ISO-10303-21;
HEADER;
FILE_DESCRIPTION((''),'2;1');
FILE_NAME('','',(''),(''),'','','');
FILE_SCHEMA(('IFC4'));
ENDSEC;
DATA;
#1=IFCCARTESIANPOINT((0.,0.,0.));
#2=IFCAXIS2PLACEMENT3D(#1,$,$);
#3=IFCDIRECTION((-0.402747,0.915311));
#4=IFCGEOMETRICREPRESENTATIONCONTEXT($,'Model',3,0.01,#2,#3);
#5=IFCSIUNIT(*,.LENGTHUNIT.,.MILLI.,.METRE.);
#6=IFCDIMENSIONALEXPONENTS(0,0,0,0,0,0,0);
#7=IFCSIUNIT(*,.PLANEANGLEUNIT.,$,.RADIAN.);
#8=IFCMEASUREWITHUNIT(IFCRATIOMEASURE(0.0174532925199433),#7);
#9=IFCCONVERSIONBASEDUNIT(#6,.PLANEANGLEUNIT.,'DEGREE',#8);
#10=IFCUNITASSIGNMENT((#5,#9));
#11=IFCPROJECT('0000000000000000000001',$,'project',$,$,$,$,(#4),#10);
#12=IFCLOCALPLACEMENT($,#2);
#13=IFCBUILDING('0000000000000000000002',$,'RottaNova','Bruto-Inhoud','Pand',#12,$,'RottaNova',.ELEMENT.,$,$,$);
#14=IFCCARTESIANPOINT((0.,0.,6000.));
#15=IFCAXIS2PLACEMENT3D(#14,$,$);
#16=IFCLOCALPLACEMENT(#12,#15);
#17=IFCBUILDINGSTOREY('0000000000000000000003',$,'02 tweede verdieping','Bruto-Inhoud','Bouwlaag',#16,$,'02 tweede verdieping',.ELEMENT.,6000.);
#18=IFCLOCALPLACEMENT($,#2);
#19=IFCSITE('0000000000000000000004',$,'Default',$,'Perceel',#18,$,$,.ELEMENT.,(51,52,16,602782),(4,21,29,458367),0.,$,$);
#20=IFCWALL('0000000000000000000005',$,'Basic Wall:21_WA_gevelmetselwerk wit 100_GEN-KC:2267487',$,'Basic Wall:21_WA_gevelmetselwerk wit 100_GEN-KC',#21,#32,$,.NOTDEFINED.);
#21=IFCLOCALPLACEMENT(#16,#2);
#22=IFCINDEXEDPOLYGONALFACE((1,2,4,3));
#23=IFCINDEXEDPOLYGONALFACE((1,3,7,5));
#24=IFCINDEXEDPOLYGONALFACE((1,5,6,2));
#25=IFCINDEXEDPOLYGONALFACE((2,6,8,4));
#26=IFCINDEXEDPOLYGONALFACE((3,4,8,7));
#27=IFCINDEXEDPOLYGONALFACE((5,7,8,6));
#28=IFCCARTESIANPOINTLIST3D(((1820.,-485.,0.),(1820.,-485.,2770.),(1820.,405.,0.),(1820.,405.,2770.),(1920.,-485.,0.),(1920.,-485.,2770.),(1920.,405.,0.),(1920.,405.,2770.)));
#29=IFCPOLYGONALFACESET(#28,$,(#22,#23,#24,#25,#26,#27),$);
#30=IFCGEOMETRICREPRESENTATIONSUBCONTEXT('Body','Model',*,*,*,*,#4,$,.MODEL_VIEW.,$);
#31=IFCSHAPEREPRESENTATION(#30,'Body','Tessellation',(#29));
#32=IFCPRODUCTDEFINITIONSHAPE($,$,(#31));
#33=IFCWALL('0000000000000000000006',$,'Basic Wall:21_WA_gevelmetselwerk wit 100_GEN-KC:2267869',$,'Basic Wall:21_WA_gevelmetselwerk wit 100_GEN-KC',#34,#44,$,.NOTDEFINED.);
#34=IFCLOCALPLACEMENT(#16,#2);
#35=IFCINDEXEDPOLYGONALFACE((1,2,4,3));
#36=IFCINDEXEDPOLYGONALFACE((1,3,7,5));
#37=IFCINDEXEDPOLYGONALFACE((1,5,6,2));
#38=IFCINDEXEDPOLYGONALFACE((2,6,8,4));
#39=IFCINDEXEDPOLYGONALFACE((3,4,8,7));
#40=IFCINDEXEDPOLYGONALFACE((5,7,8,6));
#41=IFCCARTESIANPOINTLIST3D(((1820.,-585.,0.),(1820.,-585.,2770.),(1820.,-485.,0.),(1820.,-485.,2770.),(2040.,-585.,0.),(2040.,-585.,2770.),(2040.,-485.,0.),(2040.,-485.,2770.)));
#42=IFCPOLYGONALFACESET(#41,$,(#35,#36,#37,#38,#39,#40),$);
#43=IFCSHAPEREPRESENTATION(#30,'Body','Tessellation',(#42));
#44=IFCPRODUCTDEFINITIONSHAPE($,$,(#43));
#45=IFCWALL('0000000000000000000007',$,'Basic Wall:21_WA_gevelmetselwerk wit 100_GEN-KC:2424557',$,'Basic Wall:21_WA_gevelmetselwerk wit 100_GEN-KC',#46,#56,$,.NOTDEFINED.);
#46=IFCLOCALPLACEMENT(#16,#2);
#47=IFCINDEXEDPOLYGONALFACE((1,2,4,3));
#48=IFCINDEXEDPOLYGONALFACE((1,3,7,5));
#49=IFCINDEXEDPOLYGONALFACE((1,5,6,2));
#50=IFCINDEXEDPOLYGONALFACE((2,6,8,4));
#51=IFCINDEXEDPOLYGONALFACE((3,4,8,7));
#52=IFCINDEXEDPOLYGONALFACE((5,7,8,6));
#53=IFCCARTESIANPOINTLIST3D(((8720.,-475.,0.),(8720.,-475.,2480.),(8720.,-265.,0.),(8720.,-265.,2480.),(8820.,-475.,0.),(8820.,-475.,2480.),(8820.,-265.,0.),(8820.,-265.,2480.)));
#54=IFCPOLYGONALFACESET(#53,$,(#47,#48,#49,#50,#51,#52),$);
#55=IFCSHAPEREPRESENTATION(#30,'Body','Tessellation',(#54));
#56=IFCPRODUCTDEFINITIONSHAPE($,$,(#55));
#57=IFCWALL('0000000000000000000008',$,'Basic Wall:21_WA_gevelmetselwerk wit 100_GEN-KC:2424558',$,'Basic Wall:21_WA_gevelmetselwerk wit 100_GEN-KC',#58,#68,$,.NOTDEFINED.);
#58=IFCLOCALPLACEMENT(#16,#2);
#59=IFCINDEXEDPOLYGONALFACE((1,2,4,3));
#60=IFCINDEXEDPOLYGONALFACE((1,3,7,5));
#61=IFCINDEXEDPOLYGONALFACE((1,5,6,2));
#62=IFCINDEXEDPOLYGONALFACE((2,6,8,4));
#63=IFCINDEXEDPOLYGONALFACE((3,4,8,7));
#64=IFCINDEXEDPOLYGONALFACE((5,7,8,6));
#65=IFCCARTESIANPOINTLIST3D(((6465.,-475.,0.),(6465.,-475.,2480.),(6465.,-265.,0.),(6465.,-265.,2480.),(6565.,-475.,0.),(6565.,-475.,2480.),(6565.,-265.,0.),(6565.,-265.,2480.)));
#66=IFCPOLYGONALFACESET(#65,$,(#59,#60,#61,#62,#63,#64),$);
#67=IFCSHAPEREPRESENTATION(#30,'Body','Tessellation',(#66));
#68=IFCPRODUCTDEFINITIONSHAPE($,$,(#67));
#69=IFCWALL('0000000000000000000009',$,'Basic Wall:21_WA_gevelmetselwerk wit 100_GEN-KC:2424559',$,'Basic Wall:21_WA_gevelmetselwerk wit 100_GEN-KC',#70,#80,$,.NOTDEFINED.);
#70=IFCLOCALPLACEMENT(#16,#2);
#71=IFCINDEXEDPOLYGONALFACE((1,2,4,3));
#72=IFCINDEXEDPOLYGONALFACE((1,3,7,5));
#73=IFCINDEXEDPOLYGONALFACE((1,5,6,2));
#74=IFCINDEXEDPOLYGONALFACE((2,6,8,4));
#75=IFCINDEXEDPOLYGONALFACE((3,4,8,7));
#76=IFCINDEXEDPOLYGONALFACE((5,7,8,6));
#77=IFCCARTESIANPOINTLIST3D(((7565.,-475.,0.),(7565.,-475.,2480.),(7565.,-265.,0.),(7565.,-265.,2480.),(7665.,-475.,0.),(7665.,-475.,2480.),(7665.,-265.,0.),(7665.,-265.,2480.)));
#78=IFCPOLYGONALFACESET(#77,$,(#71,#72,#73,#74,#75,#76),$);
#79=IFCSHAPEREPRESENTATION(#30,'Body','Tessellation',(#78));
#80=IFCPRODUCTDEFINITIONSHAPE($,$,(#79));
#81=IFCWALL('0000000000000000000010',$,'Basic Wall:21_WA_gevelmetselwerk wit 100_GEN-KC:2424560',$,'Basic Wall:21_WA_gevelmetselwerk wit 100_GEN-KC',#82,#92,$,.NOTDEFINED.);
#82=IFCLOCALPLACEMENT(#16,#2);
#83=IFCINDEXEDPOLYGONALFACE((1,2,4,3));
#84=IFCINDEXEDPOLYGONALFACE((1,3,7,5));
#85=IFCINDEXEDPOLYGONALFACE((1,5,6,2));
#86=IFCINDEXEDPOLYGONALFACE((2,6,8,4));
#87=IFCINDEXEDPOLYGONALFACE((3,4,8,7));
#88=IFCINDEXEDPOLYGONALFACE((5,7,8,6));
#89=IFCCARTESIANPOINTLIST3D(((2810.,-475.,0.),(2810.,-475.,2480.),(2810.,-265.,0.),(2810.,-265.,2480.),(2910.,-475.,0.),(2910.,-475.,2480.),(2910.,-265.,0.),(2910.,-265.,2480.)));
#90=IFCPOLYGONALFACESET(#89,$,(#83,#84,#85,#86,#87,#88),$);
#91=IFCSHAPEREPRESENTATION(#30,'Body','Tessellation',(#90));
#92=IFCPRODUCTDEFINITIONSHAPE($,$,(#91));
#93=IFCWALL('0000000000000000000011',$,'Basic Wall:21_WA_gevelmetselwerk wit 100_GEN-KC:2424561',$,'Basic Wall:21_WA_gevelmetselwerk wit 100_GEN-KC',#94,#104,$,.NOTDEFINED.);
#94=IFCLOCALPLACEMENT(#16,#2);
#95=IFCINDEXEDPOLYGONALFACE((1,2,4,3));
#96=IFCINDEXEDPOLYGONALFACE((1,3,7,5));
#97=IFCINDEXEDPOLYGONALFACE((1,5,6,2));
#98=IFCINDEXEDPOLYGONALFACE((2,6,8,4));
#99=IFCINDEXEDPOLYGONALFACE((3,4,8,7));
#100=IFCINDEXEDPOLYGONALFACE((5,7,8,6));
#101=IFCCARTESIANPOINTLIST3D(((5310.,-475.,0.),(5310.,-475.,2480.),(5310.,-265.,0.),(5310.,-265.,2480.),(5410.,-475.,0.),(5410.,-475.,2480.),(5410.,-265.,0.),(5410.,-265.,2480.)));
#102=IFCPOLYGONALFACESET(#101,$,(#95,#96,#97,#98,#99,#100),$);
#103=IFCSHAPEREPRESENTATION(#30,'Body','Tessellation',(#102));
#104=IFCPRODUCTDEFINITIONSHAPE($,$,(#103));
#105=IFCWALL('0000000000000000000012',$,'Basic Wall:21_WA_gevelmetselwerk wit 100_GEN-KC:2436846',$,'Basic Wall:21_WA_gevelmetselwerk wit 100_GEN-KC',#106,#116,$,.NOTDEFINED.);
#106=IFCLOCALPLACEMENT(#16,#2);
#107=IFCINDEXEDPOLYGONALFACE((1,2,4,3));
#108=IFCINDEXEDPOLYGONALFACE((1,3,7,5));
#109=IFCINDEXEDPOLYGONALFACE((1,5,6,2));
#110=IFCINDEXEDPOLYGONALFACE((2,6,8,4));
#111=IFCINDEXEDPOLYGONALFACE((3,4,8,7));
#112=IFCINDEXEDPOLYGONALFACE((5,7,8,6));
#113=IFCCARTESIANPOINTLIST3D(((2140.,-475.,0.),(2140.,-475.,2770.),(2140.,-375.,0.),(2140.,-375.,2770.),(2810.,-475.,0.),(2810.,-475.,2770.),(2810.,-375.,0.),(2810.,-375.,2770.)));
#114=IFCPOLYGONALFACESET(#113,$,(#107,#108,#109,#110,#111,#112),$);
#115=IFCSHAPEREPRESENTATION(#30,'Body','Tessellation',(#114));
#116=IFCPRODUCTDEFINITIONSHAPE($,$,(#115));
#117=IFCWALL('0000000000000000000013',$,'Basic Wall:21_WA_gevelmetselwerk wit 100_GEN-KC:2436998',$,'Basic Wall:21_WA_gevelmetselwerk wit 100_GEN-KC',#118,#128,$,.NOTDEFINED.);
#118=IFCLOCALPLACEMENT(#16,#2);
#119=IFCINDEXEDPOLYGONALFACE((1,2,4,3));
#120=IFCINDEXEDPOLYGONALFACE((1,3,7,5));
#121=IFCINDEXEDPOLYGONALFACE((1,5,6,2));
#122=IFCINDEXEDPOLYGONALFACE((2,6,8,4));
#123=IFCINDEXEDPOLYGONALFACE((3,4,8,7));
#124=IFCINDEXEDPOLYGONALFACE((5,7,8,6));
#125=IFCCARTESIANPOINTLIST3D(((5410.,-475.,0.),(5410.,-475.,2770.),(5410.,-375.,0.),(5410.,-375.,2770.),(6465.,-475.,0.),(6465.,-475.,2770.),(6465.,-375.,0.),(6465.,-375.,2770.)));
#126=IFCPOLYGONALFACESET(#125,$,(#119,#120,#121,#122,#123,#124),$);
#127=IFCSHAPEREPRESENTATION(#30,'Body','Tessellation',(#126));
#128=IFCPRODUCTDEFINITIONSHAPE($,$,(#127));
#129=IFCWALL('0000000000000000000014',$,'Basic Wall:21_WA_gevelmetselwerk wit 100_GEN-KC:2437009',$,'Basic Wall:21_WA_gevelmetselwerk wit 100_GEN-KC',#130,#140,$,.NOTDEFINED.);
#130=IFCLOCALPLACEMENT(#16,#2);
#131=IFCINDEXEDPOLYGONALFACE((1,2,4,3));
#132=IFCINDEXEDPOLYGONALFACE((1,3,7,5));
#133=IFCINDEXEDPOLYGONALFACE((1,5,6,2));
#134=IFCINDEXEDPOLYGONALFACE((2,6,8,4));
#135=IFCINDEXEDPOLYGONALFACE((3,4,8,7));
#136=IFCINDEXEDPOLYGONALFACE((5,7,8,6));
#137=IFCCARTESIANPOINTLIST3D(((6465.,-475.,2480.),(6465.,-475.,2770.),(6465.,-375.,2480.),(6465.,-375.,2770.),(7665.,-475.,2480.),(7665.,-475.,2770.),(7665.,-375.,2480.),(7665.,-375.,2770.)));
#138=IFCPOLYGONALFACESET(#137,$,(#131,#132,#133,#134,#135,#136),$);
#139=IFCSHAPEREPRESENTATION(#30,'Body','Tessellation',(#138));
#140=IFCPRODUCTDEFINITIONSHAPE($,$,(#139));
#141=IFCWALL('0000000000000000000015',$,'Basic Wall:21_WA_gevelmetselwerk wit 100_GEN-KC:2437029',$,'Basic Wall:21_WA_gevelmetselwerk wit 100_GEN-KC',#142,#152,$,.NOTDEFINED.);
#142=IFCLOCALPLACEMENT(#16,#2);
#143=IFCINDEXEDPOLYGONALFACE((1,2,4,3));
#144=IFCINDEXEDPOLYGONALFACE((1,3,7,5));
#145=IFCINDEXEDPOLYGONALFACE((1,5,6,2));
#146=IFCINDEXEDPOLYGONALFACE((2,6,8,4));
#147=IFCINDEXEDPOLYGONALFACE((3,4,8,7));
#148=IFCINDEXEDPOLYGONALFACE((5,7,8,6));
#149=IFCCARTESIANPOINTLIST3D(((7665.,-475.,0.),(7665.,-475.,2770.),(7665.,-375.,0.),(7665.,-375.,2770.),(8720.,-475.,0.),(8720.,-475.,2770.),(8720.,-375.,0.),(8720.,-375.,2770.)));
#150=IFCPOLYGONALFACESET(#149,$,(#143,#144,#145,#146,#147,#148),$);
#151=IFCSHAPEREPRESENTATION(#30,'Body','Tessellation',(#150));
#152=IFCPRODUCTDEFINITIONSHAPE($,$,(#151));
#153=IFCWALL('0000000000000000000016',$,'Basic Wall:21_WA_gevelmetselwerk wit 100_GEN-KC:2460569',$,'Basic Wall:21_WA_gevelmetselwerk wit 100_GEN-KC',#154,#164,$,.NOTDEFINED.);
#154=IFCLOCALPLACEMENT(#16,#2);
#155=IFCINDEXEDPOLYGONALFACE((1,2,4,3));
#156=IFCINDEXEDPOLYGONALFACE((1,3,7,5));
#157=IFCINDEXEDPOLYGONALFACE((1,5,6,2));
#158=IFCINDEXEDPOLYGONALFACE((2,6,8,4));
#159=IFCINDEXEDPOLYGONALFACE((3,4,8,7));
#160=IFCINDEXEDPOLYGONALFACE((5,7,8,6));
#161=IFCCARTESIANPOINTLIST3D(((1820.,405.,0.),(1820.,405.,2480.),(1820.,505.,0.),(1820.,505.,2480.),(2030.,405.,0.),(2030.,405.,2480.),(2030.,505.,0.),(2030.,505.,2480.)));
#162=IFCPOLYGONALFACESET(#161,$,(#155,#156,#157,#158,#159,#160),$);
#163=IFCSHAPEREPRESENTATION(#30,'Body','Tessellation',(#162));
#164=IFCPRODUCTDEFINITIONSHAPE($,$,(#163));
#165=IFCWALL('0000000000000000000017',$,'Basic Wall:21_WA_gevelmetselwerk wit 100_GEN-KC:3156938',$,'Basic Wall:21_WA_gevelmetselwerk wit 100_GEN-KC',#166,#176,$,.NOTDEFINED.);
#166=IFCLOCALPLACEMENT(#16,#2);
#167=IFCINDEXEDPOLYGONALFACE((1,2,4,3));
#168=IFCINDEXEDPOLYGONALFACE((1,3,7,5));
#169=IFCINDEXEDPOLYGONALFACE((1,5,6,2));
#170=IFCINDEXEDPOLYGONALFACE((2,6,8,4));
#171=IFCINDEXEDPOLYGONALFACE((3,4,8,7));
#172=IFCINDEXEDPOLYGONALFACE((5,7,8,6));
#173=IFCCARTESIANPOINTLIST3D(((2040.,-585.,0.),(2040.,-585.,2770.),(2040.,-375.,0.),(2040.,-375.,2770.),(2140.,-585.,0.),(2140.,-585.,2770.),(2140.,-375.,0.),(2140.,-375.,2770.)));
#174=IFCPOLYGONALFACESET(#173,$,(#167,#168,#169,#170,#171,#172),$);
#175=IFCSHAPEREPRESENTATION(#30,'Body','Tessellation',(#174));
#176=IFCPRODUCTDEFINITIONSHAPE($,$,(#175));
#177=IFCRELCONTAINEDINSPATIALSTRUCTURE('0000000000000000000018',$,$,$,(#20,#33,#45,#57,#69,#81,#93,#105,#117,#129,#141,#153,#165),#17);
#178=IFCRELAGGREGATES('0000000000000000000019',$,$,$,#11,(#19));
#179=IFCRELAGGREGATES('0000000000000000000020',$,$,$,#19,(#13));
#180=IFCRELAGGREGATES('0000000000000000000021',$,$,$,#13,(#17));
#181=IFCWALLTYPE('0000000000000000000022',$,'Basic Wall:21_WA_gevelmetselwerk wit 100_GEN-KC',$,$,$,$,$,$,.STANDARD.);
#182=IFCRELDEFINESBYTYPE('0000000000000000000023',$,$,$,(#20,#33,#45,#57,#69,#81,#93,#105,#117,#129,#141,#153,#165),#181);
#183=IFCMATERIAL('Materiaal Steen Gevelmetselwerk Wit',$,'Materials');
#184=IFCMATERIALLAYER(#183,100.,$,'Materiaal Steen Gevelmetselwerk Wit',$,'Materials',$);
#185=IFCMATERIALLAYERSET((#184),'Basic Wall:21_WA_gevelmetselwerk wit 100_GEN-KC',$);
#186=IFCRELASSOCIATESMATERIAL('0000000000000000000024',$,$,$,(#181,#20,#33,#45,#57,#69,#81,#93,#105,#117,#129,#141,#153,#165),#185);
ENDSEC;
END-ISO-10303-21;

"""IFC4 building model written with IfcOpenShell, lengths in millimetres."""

from ifc_helpers import new_model, entity, si_unit, converted_unit, direction, frame, frame_2d, origin, place, context, subcontext, project, spatial, rectangle, extrude, material, layer, layer_set, type_object, element, save


model = new_model("IFC4")

# Units and contexts
model_context = context("Model", 3, precision=0.01, world=origin(), true_north=direction((-0.402747, 0.915311)))
body_context = subcontext(model_context, "Body", "Model", "MODEL_VIEW")
ifc_project = project(units=[si_unit("LENGTHUNIT", "METRE", prefix="MILLI"), converted_unit("PLANEANGLEUNIT", "DEGREE", entity("IfcRatioMeasure", 0.0174532925199433), si_unit("PLANEANGLEUNIT", "RADIAN"), dimensions=[0, 0, 0, 0, 0, 0, 0])], contexts=[model_context])

# Site, building, storey
site_placement = place(None, origin())
site = spatial("IfcSite", under=ifc_project, at=site_placement, Name="Default", ObjectType="Perceel", CompositionType="ELEMENT", RefLatitude=(51, 52, 16, 602782), RefLongitude=(4, 21, 29, 458367), RefElevation=0.0)
building_placement = place(None, origin())
building = spatial("IfcBuilding", under=site, at=building_placement, Name="RottaNova", Description="Bruto-Inhoud", ObjectType="Pand", LongName="RottaNova", CompositionType="ELEMENT")
storey_placement = place(building_placement, frame((0.0, 0.0, 6000.0)))
storey = spatial("IfcBuildingStorey", under=building, at=storey_placement, Name="02 tweede verdieping", Description="Bruto-Inhoud", ObjectType="Bouwlaag", LongName="02 tweede verdieping", CompositionType="ELEMENT", Elevation=6000.0)

# Walls
ifc_material_1 = material(Name="Materiaal Steen Gevelmetselwerk Wit", Category="Materials")
ifc_layer_1 = layer(ifc_material_1, 100.0, Name="Materiaal Steen Gevelmetselwerk Wit", Category="Materials")
ifc_layer_set_1 = layer_set([ifc_layer_1], Name="Basic Wall:21_WA_gevelmetselwerk wit 100_GEN-KC")
wall_type_1 = type_object("IfcWallType", Name="Basic Wall:21_WA_gevelmetselwerk wit 100_GEN-KC", PredefinedType="STANDARD", material=ifc_layer_set_1)
wall_1_placement = place(storey_placement, frame((1870.0, 405.0, 0.0), z_axis=(0.0, 0.0, 1.0), x_axis=(0.0, -1.0, 0.0)))
element("IfcWall", 1, at=wall_1_placement, inside=storey, type_object=wall_type_1, material=ifc_layer_set_1, Name="Basic Wall:21_WA_gevelmetselwerk wit 100_GEN-KC:2267487", ObjectType="Basic Wall:21_WA_gevelmetselwerk wit 100_GEN-KC", PredefinedType="NOTDEFINED", context=body_context, shape_type="SweptSolid", body=[
    extrude(rectangle(XDim=890.0, YDim=100.0, at=frame_2d((445.0, 0.0), x_axis=(-1.0, 0.0))), origin(), (0.0, 0.0, 1.0), 2770.0),
])
wall_2_placement = place(storey_placement, frame((1820.0, -535.0, 0.0)))
element("IfcWall", 2, at=wall_2_placement, inside=storey, type_object=wall_type_1, material=ifc_layer_set_1, Name="Basic Wall:21_WA_gevelmetselwerk wit 100_GEN-KC:2267869", ObjectType="Basic Wall:21_WA_gevelmetselwerk wit 100_GEN-KC", PredefinedType="NOTDEFINED", context=body_context, shape_type="SweptSolid", body=[
    extrude(rectangle(XDim=220.0, YDim=100.0, at=frame_2d((110.0, 0.0), x_axis=(-1.0, 0.0))), origin(), (0.0, 0.0, 1.0), 2770.0),
])
for number, where, z_axis, x_axis, name in (
    (3, (8770.0, -265.0, 0.0), (0.0, 0.0, 1.0), (0.0, -1.0, 0.0), "Basic Wall:21_WA_gevelmetselwerk wit 100_GEN-KC:2424557"),
    (4, (6515.0, -265.0, 0.0), (0.0, 0.0, 1.0), (0.0, -1.0, 0.0), "Basic Wall:21_WA_gevelmetselwerk wit 100_GEN-KC:2424558"),
):
    element("IfcWall", number, at=place(storey_placement, frame(where, z_axis=z_axis, x_axis=x_axis)), inside=storey, type_object=wall_type_1, material=ifc_layer_set_1, Name=name, ObjectType="Basic Wall:21_WA_gevelmetselwerk wit 100_GEN-KC", PredefinedType="NOTDEFINED", context=body_context, shape_type="SweptSolid", body=[
        extrude(rectangle(XDim=210.0, YDim=100.0, at=frame_2d((105.0, 0.0), x_axis=(-1.0, 0.0))), origin(), (0.0, 0.0, 1.0), 2480.0),
    ])
wall_3_placement = place(storey_placement, frame((7615.0, -265.0, 0.0), z_axis=(0.0, 0.0, 1.0), x_axis=(0.0, -1.0, 0.0)))
element("IfcWall", 5, at=wall_3_placement, inside=storey, type_object=wall_type_1, material=ifc_layer_set_1, Name="Basic Wall:21_WA_gevelmetselwerk wit 100_GEN-KC:2424559", ObjectType="Basic Wall:21_WA_gevelmetselwerk wit 100_GEN-KC", PredefinedType="NOTDEFINED", context=body_context, shape_type="SweptSolid", body=[
    extrude(rectangle(XDim=210.0, YDim=100.0, at=frame_2d((105.0, 0.0), x_axis=(-1.0, 0.0))), origin(), (0.0, 0.0, 1.0), 2480.0),
])
wall_4_placement = place(storey_placement, frame((2860.0, -265.0, 0.0), z_axis=(0.0, 0.0, 1.0), x_axis=(0.0, -1.0, 0.0)))
element("IfcWall", 6, at=wall_4_placement, inside=storey, type_object=wall_type_1, material=ifc_layer_set_1, Name="Basic Wall:21_WA_gevelmetselwerk wit 100_GEN-KC:2424560", ObjectType="Basic Wall:21_WA_gevelmetselwerk wit 100_GEN-KC", PredefinedType="NOTDEFINED", context=body_context, shape_type="SweptSolid", body=[
    extrude(rectangle(XDim=210.0, YDim=100.0, at=frame_2d((105.0, 0.0), x_axis=(-1.0, 0.0))), origin(), (0.0, 0.0, 1.0), 2480.0),
])
wall_5_placement = place(storey_placement, frame((5360.0, -265.0, 0.0), z_axis=(0.0, 0.0, 1.0), x_axis=(0.0, -1.0, 0.0)))
element("IfcWall", 7, at=wall_5_placement, inside=storey, type_object=wall_type_1, material=ifc_layer_set_1, Name="Basic Wall:21_WA_gevelmetselwerk wit 100_GEN-KC:2424561", ObjectType="Basic Wall:21_WA_gevelmetselwerk wit 100_GEN-KC", PredefinedType="NOTDEFINED", context=body_context, shape_type="SweptSolid", body=[
    extrude(rectangle(XDim=210.0, YDim=100.0, at=frame_2d((105.0, 0.0), x_axis=(-1.0, 0.0))), origin(), (0.0, 0.0, 1.0), 2480.0),
])
wall_6_placement = place(storey_placement, frame((2810.0, -425.0, 0.0), z_axis=(0.0, 0.0, 1.0), x_axis=(-1.0, 0.0, 0.0)))
element("IfcWall", 8, at=wall_6_placement, inside=storey, type_object=wall_type_1, material=ifc_layer_set_1, Name="Basic Wall:21_WA_gevelmetselwerk wit 100_GEN-KC:2436846", ObjectType="Basic Wall:21_WA_gevelmetselwerk wit 100_GEN-KC", PredefinedType="NOTDEFINED", context=body_context, shape_type="SweptSolid", body=[
    extrude(rectangle(XDim=670.0, YDim=100.0, at=frame_2d((335.0, 0.0), x_axis=(-1.0, 0.0))), origin(), (0.0, 0.0, 1.0), 2770.0),
])
wall_7_placement = place(storey_placement, frame((6465.0, -425.0, 0.0), z_axis=(0.0, 0.0, 1.0), x_axis=(-1.0, 0.0, 0.0)))
element("IfcWall", 9, at=wall_7_placement, inside=storey, type_object=wall_type_1, material=ifc_layer_set_1, Name="Basic Wall:21_WA_gevelmetselwerk wit 100_GEN-KC:2436998", ObjectType="Basic Wall:21_WA_gevelmetselwerk wit 100_GEN-KC", PredefinedType="NOTDEFINED", context=body_context, shape_type="SweptSolid", body=[
    extrude(rectangle(XDim=1055.0, YDim=100.0, at=frame_2d((527.5, 0.0), x_axis=(-1.0, 0.0))), origin(), (0.0, 0.0, 1.0), 2770.0),
])
wall_8_placement = place(storey_placement, frame((7665.0, -425.0, 2480.0), z_axis=(0.0, 0.0, 1.0), x_axis=(-1.0, 0.0, 0.0)))
element("IfcWall", 10, at=wall_8_placement, inside=storey, type_object=wall_type_1, material=ifc_layer_set_1, Name="Basic Wall:21_WA_gevelmetselwerk wit 100_GEN-KC:2437009", ObjectType="Basic Wall:21_WA_gevelmetselwerk wit 100_GEN-KC", PredefinedType="NOTDEFINED", context=body_context, shape_type="SweptSolid", body=[
    extrude(rectangle(XDim=1200.0, YDim=100.0, at=frame_2d((600.0, 0.0), x_axis=(-1.0, 0.0))), origin(), (0.0, 0.0, 1.0), 290.0),
])
wall_9_placement = place(storey_placement, frame((8720.0, -425.0, 0.0), z_axis=(0.0, 0.0, 1.0), x_axis=(-1.0, 0.0, 0.0)))
element("IfcWall", 11, at=wall_9_placement, inside=storey, type_object=wall_type_1, material=ifc_layer_set_1, Name="Basic Wall:21_WA_gevelmetselwerk wit 100_GEN-KC:2437029", ObjectType="Basic Wall:21_WA_gevelmetselwerk wit 100_GEN-KC", PredefinedType="NOTDEFINED", context=body_context, shape_type="SweptSolid", body=[
    extrude(rectangle(XDim=1055.0, YDim=100.0, at=frame_2d((527.5, 0.0), x_axis=(-1.0, 0.0))), origin(), (0.0, 0.0, 1.0), 2770.0),
])
wall_10_placement = place(storey_placement, frame((2030.0, 455.0, 0.0), z_axis=(0.0, 0.0, 1.0), x_axis=(-1.0, 0.0, 0.0)))
element("IfcWall", 12, at=wall_10_placement, inside=storey, type_object=wall_type_1, material=ifc_layer_set_1, Name="Basic Wall:21_WA_gevelmetselwerk wit 100_GEN-KC:2460569", ObjectType="Basic Wall:21_WA_gevelmetselwerk wit 100_GEN-KC", PredefinedType="NOTDEFINED", context=body_context, shape_type="SweptSolid", body=[
    extrude(rectangle(XDim=210.0, YDim=100.0, at=frame_2d((105.0, 0.0), x_axis=(-1.0, 0.0))), origin(), (0.0, 0.0, 1.0), 2480.0),
])
wall_11_placement = place(storey_placement, frame((2090.0, -585.0, 0.0), z_axis=(0.0, 0.0, 1.0), x_axis=(0.0, 1.0, 0.0)))
element("IfcWall", 13, at=wall_11_placement, inside=storey, type_object=wall_type_1, material=ifc_layer_set_1, Name="Basic Wall:21_WA_gevelmetselwerk wit 100_GEN-KC:3156938", ObjectType="Basic Wall:21_WA_gevelmetselwerk wit 100_GEN-KC", PredefinedType="NOTDEFINED", context=body_context, shape_type="SweptSolid", body=[
    extrude(rectangle(XDim=210.0, YDim=100.0, at=frame_2d((105.0, 0.0), x_axis=(-1.0, 0.0))), origin(), (0.0, 0.0, 1.0), 2770.0),
])

save(model, "model.ifc")
